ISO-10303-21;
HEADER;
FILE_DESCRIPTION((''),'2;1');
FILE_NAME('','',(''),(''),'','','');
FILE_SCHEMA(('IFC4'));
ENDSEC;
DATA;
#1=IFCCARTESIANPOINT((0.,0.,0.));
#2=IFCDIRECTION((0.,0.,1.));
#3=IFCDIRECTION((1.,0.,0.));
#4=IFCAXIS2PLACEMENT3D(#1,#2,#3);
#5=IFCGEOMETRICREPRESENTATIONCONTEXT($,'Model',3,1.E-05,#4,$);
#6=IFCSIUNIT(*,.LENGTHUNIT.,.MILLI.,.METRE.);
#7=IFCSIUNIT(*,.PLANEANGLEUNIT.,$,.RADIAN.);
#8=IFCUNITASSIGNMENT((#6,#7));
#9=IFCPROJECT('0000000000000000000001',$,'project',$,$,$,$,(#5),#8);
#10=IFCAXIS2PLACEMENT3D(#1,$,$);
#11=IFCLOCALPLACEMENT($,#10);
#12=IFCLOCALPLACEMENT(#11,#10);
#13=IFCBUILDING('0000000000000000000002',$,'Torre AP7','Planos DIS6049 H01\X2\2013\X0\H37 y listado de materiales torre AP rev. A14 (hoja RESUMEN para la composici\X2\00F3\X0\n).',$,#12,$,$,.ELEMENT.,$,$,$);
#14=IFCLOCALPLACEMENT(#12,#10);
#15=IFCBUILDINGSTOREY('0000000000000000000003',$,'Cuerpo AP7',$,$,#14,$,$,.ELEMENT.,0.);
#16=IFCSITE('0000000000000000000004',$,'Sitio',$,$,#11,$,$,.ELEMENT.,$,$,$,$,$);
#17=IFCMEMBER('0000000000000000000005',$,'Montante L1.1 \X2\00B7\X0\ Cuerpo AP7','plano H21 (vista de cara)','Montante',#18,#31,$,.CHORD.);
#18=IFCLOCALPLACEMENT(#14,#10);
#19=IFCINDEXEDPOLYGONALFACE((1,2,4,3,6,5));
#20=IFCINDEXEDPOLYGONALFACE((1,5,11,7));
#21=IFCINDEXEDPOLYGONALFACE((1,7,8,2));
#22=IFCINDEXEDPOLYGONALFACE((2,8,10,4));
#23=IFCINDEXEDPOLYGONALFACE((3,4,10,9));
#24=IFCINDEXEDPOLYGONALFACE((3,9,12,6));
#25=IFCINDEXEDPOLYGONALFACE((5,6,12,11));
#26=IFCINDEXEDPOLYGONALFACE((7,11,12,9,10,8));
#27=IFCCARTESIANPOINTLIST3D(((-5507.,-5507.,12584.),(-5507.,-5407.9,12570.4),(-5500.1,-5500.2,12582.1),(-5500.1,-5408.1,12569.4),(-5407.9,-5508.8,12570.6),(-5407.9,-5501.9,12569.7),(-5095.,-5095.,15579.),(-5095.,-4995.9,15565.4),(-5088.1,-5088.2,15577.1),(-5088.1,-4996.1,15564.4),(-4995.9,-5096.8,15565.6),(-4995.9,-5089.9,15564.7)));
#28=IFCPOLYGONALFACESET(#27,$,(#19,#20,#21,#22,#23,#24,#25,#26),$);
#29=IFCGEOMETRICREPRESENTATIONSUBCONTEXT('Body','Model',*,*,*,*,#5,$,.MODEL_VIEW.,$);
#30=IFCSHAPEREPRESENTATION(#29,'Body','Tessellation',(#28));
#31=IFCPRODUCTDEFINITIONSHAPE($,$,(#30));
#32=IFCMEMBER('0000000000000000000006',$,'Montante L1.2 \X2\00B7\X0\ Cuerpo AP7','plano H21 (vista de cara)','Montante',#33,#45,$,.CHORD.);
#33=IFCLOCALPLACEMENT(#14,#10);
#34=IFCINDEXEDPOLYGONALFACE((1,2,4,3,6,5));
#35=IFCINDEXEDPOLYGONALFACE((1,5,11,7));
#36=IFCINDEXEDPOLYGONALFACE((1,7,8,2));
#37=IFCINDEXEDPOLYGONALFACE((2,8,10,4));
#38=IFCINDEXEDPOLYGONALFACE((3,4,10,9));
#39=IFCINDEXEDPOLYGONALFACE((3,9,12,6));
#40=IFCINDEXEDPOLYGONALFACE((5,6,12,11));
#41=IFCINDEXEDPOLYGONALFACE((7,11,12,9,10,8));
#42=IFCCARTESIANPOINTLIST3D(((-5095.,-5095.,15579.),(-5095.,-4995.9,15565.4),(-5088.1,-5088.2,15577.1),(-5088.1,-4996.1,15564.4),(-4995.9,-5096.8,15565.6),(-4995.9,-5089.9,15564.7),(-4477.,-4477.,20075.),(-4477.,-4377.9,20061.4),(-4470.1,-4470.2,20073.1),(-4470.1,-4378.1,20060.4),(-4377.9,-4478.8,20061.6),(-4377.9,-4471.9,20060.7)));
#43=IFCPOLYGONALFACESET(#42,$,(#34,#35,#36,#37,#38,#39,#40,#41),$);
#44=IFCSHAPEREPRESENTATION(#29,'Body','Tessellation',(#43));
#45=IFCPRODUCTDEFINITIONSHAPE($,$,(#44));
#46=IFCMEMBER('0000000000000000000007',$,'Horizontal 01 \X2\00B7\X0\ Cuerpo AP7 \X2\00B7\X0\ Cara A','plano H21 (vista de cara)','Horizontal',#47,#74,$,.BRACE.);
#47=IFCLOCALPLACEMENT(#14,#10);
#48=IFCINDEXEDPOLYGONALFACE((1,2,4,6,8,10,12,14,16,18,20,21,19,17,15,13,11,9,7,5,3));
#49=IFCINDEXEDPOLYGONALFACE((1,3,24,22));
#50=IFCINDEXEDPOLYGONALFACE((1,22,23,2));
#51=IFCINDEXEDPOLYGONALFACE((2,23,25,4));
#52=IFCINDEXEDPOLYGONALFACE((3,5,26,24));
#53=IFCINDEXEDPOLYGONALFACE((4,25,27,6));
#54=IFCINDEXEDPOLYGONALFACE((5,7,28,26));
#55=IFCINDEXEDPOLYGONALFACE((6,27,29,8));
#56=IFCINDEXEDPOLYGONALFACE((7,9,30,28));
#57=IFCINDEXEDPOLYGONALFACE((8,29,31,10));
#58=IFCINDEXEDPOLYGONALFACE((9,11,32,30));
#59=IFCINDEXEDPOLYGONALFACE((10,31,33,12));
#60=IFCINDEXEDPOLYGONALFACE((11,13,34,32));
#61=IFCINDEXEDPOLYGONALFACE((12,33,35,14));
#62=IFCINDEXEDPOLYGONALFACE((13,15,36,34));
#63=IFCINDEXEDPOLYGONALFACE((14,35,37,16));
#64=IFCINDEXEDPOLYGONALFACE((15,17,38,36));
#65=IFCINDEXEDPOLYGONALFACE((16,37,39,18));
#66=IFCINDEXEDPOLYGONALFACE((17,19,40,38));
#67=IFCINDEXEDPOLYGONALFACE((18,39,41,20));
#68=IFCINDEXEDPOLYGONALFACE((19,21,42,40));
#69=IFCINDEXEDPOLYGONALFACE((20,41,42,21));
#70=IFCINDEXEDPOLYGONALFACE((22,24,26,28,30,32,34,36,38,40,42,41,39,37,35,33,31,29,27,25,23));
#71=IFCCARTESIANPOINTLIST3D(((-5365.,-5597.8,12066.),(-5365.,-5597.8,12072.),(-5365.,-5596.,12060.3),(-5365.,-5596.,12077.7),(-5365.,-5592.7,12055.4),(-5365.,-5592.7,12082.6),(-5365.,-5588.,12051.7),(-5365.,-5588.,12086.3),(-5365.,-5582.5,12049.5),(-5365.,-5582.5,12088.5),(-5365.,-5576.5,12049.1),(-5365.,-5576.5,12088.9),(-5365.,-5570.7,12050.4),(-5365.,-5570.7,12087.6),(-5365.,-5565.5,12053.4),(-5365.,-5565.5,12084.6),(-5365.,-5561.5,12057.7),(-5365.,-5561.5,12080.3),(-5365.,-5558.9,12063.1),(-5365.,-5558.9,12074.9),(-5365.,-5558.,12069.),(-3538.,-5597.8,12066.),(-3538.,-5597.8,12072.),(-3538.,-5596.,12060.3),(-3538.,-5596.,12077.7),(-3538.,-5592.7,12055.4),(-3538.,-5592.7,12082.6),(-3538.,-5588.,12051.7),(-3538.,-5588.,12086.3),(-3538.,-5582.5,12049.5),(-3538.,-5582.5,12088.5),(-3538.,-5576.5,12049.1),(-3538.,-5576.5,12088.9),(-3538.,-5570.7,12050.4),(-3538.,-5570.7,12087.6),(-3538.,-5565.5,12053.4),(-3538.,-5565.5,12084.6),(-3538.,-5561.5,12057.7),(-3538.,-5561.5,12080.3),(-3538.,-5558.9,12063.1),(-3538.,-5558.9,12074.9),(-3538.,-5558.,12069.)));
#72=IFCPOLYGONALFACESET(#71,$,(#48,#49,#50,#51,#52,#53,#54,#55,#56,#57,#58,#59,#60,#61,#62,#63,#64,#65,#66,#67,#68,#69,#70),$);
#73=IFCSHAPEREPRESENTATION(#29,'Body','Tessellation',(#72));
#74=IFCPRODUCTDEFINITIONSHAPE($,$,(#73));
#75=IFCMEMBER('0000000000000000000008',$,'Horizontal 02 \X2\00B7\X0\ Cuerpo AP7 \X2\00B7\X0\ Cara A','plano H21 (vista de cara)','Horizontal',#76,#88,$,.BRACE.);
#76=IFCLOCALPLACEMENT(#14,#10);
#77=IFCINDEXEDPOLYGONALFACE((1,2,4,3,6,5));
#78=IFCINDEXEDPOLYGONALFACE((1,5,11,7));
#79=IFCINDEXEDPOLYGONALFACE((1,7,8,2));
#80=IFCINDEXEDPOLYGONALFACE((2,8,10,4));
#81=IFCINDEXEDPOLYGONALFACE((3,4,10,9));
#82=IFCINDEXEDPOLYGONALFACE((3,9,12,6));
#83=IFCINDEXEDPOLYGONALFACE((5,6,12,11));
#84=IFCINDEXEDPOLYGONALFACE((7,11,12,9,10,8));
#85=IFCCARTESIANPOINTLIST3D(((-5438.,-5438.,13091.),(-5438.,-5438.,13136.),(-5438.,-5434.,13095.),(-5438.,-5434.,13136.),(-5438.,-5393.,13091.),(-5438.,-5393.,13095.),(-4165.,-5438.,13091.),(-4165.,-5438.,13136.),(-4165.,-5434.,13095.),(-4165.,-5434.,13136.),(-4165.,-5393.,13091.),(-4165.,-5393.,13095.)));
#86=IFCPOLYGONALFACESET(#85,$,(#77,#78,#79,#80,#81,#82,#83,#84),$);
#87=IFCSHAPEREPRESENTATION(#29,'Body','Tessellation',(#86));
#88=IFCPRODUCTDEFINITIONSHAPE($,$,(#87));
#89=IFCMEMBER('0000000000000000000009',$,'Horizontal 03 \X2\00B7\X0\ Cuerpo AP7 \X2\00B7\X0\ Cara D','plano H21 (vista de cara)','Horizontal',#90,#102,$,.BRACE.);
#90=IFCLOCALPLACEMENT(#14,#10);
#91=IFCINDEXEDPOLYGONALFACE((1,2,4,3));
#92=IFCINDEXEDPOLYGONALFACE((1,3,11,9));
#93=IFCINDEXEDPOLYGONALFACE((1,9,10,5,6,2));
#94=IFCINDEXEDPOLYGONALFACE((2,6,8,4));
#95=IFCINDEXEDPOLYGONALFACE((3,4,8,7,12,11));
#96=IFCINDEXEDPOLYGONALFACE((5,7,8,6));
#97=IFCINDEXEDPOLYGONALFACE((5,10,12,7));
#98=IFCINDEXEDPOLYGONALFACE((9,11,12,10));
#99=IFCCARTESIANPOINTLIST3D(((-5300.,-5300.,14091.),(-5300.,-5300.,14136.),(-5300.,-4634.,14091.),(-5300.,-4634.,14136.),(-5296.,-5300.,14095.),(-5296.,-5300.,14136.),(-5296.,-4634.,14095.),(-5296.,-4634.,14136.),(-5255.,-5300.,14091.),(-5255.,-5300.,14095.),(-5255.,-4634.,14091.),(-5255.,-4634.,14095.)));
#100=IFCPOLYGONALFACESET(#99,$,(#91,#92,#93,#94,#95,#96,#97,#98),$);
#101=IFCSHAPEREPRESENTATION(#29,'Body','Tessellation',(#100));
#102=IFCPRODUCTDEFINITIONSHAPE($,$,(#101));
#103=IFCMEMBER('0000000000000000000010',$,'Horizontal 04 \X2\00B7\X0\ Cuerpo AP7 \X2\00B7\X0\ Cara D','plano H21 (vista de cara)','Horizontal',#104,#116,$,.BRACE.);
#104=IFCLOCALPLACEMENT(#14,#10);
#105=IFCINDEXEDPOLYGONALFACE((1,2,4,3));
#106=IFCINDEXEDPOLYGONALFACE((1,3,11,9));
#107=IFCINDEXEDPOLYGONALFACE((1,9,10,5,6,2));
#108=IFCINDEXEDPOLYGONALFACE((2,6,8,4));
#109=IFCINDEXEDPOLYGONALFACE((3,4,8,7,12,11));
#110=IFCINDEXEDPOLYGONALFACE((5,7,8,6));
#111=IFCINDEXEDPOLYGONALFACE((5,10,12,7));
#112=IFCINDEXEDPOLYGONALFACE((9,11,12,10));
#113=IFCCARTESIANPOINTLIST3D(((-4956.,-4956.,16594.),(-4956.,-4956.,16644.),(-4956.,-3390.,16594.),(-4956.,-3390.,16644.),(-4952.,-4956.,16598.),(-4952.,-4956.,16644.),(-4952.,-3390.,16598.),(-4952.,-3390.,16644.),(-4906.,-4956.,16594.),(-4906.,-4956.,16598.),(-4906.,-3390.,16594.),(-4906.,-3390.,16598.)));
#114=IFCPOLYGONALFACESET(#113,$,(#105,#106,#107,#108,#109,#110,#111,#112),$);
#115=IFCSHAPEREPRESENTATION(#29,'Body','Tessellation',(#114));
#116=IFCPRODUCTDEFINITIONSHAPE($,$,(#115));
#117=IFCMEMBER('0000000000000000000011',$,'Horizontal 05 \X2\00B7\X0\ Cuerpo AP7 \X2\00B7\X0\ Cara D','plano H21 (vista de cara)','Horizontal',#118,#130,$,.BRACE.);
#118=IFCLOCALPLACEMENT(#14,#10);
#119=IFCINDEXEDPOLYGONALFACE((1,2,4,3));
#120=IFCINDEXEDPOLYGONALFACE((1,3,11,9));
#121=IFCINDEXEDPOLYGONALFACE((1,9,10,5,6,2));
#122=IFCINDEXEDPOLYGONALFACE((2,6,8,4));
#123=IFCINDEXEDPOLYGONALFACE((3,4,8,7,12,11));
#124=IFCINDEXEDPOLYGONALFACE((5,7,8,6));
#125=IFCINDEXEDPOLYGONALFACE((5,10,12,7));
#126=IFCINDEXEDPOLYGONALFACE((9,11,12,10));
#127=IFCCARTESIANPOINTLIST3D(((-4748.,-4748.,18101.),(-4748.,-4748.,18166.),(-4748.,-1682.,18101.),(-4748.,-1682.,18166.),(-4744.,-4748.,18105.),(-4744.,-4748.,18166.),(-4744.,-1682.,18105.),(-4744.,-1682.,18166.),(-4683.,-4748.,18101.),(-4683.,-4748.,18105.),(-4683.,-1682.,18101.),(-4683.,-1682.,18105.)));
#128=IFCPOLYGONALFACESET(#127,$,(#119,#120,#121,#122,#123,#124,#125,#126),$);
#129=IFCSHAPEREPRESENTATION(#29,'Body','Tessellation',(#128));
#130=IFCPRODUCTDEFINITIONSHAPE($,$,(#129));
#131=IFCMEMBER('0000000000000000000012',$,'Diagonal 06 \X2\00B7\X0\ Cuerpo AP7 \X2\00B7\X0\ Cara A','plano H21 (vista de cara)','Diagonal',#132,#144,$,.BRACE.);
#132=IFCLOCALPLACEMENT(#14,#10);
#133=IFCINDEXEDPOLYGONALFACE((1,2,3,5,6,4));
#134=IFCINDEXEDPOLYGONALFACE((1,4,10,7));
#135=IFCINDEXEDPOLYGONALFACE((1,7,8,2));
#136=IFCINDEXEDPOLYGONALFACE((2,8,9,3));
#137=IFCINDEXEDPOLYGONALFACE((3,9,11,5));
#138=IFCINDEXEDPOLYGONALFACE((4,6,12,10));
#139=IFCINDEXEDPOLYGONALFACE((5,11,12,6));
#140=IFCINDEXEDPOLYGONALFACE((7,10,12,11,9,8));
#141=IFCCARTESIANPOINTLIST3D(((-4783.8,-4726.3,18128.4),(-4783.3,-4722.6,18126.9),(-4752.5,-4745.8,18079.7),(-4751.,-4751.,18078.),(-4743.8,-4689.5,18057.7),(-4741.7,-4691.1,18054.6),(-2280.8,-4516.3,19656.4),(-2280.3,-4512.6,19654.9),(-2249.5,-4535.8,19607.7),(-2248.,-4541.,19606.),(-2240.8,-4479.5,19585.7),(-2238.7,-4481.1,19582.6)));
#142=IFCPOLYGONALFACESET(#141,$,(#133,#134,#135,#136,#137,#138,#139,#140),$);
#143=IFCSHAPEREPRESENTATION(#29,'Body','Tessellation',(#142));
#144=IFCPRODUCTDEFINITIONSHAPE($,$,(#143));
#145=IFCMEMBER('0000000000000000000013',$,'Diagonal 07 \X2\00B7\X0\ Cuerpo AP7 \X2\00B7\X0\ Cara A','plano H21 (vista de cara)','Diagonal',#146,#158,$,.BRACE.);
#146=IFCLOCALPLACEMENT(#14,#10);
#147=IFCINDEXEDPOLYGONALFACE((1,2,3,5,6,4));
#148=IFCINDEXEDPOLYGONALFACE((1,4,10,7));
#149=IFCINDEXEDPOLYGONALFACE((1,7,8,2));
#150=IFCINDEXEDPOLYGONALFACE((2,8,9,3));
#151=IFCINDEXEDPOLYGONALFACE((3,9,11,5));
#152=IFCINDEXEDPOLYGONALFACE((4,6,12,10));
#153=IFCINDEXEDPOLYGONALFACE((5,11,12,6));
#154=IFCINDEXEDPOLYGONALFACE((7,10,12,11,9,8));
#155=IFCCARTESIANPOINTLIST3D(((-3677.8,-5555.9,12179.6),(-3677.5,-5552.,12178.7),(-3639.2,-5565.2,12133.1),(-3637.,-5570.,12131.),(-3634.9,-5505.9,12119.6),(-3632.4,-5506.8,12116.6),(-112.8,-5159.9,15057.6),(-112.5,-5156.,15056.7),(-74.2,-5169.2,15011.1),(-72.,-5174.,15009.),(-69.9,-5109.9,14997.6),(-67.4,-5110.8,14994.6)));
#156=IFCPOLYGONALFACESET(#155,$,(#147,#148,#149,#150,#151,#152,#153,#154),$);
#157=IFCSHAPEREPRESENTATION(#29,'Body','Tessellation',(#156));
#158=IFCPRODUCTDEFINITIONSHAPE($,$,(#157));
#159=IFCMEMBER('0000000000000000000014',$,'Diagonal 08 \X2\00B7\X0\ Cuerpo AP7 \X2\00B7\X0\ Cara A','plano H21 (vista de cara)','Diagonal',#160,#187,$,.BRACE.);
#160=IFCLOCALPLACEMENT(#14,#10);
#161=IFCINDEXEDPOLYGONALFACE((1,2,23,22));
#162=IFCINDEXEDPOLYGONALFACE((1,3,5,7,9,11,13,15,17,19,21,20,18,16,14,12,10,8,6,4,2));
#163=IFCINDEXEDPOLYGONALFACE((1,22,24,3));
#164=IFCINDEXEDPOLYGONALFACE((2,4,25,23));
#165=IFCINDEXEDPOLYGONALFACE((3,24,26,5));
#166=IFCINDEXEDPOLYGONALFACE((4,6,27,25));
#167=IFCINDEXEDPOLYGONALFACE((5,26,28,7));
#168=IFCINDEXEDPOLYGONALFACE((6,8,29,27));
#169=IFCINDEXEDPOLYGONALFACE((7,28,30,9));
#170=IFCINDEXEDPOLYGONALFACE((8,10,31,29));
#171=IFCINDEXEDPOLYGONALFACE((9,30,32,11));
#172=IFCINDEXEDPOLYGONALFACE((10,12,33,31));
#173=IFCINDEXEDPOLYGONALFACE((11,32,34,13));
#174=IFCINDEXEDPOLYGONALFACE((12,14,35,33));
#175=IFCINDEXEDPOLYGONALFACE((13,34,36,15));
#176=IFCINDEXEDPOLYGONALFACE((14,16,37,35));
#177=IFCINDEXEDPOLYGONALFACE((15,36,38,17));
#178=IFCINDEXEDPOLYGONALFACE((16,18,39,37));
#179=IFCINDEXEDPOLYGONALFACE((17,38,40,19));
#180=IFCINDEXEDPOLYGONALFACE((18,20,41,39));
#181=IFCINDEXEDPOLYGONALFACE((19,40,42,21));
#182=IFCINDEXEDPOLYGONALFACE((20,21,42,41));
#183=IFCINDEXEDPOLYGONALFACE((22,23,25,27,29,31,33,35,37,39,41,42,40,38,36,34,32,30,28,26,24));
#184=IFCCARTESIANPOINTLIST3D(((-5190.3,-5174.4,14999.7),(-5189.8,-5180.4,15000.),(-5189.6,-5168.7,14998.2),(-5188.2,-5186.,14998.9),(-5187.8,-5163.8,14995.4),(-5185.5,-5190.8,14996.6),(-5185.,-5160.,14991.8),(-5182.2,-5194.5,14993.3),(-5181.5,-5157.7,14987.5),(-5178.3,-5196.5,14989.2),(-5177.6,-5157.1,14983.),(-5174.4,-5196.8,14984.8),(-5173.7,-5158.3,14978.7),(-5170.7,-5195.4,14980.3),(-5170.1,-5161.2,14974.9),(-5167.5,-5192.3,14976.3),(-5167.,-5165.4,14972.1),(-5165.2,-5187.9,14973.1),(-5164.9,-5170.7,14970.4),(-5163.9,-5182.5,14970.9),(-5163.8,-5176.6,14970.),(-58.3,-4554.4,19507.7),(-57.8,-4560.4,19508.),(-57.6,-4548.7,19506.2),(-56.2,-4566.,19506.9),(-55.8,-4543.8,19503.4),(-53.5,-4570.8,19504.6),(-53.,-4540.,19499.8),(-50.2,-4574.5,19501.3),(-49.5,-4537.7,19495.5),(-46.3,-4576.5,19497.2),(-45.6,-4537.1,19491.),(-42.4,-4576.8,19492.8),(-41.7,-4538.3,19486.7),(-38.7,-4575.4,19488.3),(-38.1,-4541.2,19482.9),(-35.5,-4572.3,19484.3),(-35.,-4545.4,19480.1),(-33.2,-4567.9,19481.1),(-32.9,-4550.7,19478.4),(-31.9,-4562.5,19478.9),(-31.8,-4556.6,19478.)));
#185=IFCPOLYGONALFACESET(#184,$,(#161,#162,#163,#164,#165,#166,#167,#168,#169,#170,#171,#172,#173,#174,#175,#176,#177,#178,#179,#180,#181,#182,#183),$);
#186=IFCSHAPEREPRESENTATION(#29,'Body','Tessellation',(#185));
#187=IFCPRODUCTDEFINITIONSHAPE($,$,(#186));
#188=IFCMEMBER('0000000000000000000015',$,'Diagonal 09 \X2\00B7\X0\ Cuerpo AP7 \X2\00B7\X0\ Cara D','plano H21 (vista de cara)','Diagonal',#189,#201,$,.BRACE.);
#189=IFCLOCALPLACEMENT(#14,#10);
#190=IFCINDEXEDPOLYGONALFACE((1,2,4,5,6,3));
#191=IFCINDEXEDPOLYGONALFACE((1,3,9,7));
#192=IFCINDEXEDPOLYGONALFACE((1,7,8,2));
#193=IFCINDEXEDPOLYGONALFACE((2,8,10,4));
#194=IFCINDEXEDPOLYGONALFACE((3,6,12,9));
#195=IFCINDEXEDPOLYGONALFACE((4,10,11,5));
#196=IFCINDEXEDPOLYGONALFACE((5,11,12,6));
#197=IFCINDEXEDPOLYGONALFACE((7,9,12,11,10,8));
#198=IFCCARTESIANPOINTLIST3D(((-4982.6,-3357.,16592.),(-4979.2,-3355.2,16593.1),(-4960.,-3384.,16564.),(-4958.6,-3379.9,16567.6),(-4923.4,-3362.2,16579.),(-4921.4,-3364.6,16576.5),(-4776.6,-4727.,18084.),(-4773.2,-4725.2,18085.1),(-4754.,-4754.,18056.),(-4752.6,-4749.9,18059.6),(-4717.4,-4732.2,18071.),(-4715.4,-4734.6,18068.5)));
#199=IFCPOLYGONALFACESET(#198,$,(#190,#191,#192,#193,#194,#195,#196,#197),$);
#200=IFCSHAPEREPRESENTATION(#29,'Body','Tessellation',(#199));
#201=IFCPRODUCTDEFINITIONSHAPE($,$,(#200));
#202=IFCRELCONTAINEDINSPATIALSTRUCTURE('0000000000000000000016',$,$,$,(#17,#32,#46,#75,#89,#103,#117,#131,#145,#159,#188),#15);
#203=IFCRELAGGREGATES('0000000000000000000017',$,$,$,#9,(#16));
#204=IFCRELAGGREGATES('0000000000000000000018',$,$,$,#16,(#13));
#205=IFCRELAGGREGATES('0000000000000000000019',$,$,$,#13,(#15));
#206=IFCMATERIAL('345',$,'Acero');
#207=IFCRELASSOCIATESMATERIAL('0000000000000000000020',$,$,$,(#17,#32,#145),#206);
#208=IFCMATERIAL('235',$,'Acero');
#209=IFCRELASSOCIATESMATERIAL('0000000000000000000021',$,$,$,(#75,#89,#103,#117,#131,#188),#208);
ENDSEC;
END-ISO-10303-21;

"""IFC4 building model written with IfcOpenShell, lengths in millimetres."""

from ifc_helpers import new_model, si_unit, frame, frame_2d, origin, origin_with_axes, place, context, subcontext, project, spatial, circle, l_section, extrude, material, element, save


model = new_model("IFC4")

# Units and contexts
model_context = context("Model", 3, precision=1e-05, world=origin_with_axes())
body_context = subcontext(model_context, "Body", "Model", "MODEL_VIEW")
ifc_project = project(units=[si_unit("LENGTHUNIT", "METRE", prefix="MILLI"), si_unit("PLANEANGLEUNIT", "RADIAN")], contexts=[model_context])

# Site, building, storey
site_placement = place(None, origin())
site = spatial("IfcSite", under=ifc_project, at=site_placement, Name="Sitio", CompositionType="ELEMENT")
building_placement = place(site_placement, origin())
building = spatial("IfcBuilding", under=site, at=building_placement, Name="Torre AP7", Description="Planos DIS6049 H01–H37 y listado de materiales torre AP rev. A14 (hoja RESUMEN para la composición).", CompositionType="ELEMENT")
storey_placement = place(building_placement, origin())
storey = spatial("IfcBuildingStorey", under=building, at=storey_placement, Name="Cuerpo AP7", CompositionType="ELEMENT", Elevation=0.0)

# Members
ifc_material_1 = material(Name="345", Category="Acero")
member_1_placement = place(storey_placement, frame((-5507.0, -5507.0, 12584.0), z_axis=(0.135031, 0.135031, 0.981597), x_axis=(0.990841, -0.018402, -0.133771)))
element("IfcMember", 1, at=member_1_placement, inside=storey, material=ifc_material_1, Name="Montante L1.1 · Cuerpo AP7", Description="plano H21 (vista de cara)", ObjectType="Montante", PredefinedType="CHORD", context=body_context, shape_type="SweptSolid", body=[
    extrude(l_section(Depth=100.0, Width=100.0, Thickness=7.0, at=frame_2d((50.0, 50.0))), None, (0.0, 0.0, 1.0), 3051.1),
])
member_2_placement = place(storey_placement, frame((-5095.0, -5095.0, 15579.0), z_axis=(0.13493, 0.13493, 0.981625), x_axis=(0.990855, -0.018374, -0.133673)))
element("IfcMember", 2, at=member_2_placement, inside=storey, material=ifc_material_1, Name="Montante L1.2 · Cuerpo AP7", Description="plano H21 (vista de cara)", ObjectType="Montante", PredefinedType="CHORD", context=body_context, shape_type="SweptSolid", body=[
    extrude(l_section(Depth=100.0, Width=100.0, Thickness=7.0, at=frame_2d((50.0, 50.0))), None, (0.0, 0.0, 1.0), 4580.2),
])
member_3_placement = place(storey_placement, frame((-5365.0, -5578.0, 12069.0), z_axis=(1.0, 0.0, 0.0), x_axis=(0.0, 1.0, 0.0)))
element("IfcMember", 3, at=member_3_placement, inside=storey, Name="Horizontal 01 · Cuerpo AP7 · Cara A", Description="plano H21 (vista de cara)", ObjectType="Horizontal", PredefinedType="BRACE", context=body_context, shape_type="SweptSolid", body=[
    extrude(circle(Radius=20.0), None, (0.0, 0.0, 1.0), 1827.0),
])
ifc_material_2 = material(Name="235", Category="Acero")
member_4_placement = place(storey_placement, frame((-5438.0, -5438.0, 13091.0), z_axis=(1.0, 0.0, 0.0), x_axis=(0.0, 1.0, 0.0)))
element("IfcMember", 4, at=member_4_placement, inside=storey, material=ifc_material_2, Name="Horizontal 02 · Cuerpo AP7 · Cara A", Description="plano H21 (vista de cara)", ObjectType="Horizontal", PredefinedType="BRACE", context=body_context, shape_type="SweptSolid", body=[
    extrude(l_section(Depth=45.0, Width=45.0, Thickness=4.0, at=frame_2d((22.5, 22.5))), None, (0.0, 0.0, 1.0), 1273.0),
])
member_5_placement = place(storey_placement, frame((-5300.0, -4634.0, 14091.0), z_axis=(0.0, -1.0, 0.0), x_axis=(1.0, 0.0, 0.0)))
element("IfcMember", 5, at=member_5_placement, inside=storey, material=ifc_material_2, Name="Horizontal 03 · Cuerpo AP7 · Cara D", Description="plano H21 (vista de cara)", ObjectType="Horizontal", PredefinedType="BRACE", context=body_context, shape_type="SweptSolid", body=[
    extrude(l_section(Depth=45.0, Width=45.0, Thickness=4.0, at=frame_2d((22.5, 22.5))), None, (0.0, 0.0, 1.0), 666.0),
])
member_6_placement = place(storey_placement, frame((-4956.0, -3390.0, 16594.0), z_axis=(0.0, -1.0, 0.0), x_axis=(1.0, 0.0, 0.0)))
element("IfcMember", 6, at=member_6_placement, inside=storey, material=ifc_material_2, Name="Horizontal 04 · Cuerpo AP7 · Cara D", Description="plano H21 (vista de cara)", ObjectType="Horizontal", PredefinedType="BRACE", context=body_context, shape_type="SweptSolid", body=[
    extrude(l_section(Depth=50.0, Width=50.0, Thickness=4.0, at=frame_2d((25.0, 25.0))), None, (0.0, 0.0, 1.0), 1566.0),
])
member_7_placement = place(storey_placement, frame((-4748.0, -1682.0, 18101.0), z_axis=(0.0, -1.0, 0.0), x_axis=(1.0, 0.0, 0.0)))
element("IfcMember", 7, at=member_7_placement, inside=storey, material=ifc_material_2, Name="Horizontal 05 · Cuerpo AP7 · Cara D", Description="plano H21 (vista de cara)", ObjectType="Horizontal", PredefinedType="BRACE", context=body_context, shape_type="SweptSolid", body=[
    extrude(l_section(Depth=65.0, Width=65.0, Thickness=4.0, at=frame_2d((32.5, 32.5))), None, (0.0, 0.0, 1.0), 3066.0),
])
member_8_placement = place(storey_placement, frame((-4751.0, -4751.0, 18078.0), z_axis=(0.851346, 0.071427, 0.519719), x_axis=(0.142318, 0.922089, -0.359857)))
element("IfcMember", 8, at=member_8_placement, inside=storey, material=ifc_material_2, Name="Diagonal 06 · Cuerpo AP7 · Cara A", Description="plano H21 (vista de cara)", ObjectType="Diagonal", PredefinedType="BRACE", context=body_context, shape_type="SweptSolid", body=[
    extrude(l_section(Depth=65.0, Width=65.0, Thickness=4.0, at=frame_2d((32.5, 32.5))), None, (0.0, 0.0, 1.0), 2940.0),
])
member_9_placement = place(storey_placement, frame((-3637.0, -5570.0, 12131.0), z_axis=(0.775203, 0.086109, 0.625816), x_axis=(0.071222, 0.972436, -0.222026)))
element("IfcMember", 9, at=member_9_placement, inside=storey, material=ifc_material_1, Name="Diagonal 07 · Cuerpo AP7 · Cara A", Description="plano H21 (vista de cara)", ObjectType="Diagonal", PredefinedType="BRACE", context=body_context, shape_type="SweptSolid", body=[
    extrude(l_section(Depth=65.0, Width=65.0, Thickness=4.0, at=frame_2d((32.5, 32.5))), None, (0.0, 0.0, 1.0), 4598.8),
])
member_10_placement = place(storey_placement, frame((-5177.0, -5177.0, 14985.0), z_axis=(0.74823, 0.090394, 0.657253), x_axis=(0.164751, 0.934326, -0.316057)))
element("IfcMember", 10, at=member_10_placement, inside=storey, Name="Diagonal 08 · Cuerpo AP7 · Cara A", Description="plano H21 (vista de cara)", ObjectType="Diagonal", PredefinedType="BRACE", context=body_context, shape_type="SweptSolid", body=[
    extrude(circle(Radius=20.0), None, (0.0, 0.0, 1.0), 6858.9),
])
member_11_placement = place(storey_placement, frame((-4960.0, -3384.0, 16564.0), z_axis=(0.101178, -0.67288, 0.7328), x_axis=(0.858174, 0.431654, 0.27787)))
element("IfcMember", 11, at=member_11_placement, inside=storey, material=ifc_material_2, Name="Diagonal 09 · Cuerpo AP7 · Cara D", Description="plano H21 (vista de cara)", ObjectType="Diagonal", PredefinedType="BRACE", context=body_context, shape_type="SweptSolid", body=[
    extrude(l_section(Depth=45.0, Width=45.0, Thickness=4.0, at=frame_2d((22.5, 22.5))), None, (0.0, 0.0, 1.0), 2036.0),
])

save(model, "model.ifc")
